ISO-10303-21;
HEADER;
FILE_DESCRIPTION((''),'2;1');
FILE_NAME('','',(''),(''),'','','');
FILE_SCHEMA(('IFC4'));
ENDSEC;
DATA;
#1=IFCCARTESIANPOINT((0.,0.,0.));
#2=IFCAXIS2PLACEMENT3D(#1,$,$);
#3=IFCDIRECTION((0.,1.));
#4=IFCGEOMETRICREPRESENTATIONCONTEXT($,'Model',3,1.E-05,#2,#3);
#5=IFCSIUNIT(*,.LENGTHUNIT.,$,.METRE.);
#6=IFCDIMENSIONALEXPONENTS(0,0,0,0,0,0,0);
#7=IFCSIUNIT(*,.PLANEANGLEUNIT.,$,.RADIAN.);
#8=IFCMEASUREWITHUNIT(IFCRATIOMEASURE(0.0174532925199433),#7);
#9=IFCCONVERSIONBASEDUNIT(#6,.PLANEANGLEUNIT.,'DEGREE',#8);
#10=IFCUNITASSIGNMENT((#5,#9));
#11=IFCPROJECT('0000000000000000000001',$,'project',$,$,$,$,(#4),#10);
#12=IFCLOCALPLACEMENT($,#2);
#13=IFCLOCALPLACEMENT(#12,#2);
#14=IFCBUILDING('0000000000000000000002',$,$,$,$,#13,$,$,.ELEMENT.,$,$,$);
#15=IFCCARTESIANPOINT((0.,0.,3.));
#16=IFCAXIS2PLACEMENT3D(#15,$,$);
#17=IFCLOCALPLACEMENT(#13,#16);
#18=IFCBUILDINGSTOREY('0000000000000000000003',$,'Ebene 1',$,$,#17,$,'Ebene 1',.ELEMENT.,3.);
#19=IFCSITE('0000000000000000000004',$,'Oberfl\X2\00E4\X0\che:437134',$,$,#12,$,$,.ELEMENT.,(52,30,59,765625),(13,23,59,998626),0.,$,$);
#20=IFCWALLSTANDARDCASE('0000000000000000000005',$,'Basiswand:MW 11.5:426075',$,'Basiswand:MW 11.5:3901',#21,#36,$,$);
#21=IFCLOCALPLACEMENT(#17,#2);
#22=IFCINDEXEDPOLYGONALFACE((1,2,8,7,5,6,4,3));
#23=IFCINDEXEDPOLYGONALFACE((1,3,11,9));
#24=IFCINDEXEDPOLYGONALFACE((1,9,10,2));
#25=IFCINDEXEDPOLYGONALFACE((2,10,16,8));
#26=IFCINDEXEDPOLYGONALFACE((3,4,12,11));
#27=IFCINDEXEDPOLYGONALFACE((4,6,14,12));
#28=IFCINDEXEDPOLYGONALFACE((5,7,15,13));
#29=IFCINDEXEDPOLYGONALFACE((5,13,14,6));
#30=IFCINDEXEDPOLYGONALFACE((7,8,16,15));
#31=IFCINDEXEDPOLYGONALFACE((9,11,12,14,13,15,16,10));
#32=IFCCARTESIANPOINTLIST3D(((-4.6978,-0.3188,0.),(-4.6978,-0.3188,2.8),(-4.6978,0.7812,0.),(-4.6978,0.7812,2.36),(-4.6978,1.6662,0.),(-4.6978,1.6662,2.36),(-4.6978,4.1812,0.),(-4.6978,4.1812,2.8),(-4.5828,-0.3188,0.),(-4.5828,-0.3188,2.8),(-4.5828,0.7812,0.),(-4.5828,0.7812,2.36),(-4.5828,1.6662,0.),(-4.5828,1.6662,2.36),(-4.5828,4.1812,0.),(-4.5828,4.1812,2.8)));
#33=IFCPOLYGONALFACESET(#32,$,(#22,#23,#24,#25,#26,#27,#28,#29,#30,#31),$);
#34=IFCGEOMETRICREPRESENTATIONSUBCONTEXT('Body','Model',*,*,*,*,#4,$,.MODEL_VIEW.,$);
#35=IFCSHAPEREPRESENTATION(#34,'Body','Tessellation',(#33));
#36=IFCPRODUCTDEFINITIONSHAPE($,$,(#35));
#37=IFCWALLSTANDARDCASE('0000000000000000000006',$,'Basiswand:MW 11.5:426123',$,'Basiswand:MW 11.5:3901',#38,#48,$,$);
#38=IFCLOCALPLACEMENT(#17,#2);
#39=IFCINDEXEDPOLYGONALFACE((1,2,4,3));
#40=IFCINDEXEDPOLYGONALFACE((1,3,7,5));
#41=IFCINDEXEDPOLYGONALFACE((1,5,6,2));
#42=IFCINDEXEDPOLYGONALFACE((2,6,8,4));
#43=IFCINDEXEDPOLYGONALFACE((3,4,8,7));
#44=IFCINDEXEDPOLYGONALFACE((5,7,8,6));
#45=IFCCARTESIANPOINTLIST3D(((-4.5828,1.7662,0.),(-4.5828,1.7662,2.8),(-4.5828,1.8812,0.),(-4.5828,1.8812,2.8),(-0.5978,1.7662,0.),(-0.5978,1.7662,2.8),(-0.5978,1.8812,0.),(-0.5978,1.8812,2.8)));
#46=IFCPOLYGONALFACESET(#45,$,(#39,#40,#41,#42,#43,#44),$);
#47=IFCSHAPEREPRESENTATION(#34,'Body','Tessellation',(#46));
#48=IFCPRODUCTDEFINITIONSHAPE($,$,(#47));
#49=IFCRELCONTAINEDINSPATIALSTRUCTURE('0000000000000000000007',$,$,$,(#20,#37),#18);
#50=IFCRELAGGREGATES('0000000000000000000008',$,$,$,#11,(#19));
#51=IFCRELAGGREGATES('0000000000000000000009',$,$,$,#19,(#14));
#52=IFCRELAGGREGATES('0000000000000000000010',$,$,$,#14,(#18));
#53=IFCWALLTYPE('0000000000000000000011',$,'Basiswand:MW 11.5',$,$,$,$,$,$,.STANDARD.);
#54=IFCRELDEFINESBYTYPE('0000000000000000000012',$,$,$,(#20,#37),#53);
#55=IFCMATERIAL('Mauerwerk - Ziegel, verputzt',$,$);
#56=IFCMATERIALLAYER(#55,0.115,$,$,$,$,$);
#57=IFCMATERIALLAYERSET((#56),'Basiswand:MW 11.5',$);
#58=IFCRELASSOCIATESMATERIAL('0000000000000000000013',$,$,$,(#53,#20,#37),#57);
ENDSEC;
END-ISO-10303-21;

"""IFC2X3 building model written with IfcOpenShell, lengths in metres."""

from ifc_helpers import new_model, entity, si_unit, converted_unit, direction, frame, frame_2d, origin, place, context, subcontext, project, spatial, polyline, rectangle, extrude, clip, bounded_halfspace, material, layer, layer_set, layer_usage, type_object, element, save


model = new_model("IFC2X3")

# Units and contexts
model_context = context("Model", 3, precision=1e-05, world=origin(), true_north=direction((0.0, 1.0)))
body_context = subcontext(model_context, "Body", "Model", "MODEL_VIEW")
ifc_project = project(units=[si_unit("LENGTHUNIT", "METRE"), converted_unit("PLANEANGLEUNIT", "DEGREE", entity("IfcRatioMeasure", 0.0174532925199433), si_unit("PLANEANGLEUNIT", "RADIAN"), dimensions=[0, 0, 0, 0, 0, 0, 0])], contexts=[model_context])

# Site, building, storey
site_placement = place(None, origin())
site = spatial("IfcSite", under=ifc_project, at=site_placement, Name="Oberfläche:437134", CompositionType="ELEMENT", RefLatitude=(52, 30, 59, 765625), RefLongitude=(13, 23, 59, 998626), RefElevation=0.0)
building_placement = place(site_placement, origin())
building = spatial("IfcBuilding", under=site, at=building_placement, CompositionType="ELEMENT")
storey_placement = place(building_placement, frame((0.0, 0.0, 3.0)))
storey = spatial("IfcBuildingStorey", under=building, at=storey_placement, Name="Ebene 1", LongName="Ebene 1", CompositionType="ELEMENT", Elevation=3.0)

# Shared definitions
ifc_material_1 = material(Name="Mauerwerk - Ziegel, verputzt")

# Wall, opening
ifc_layer_1 = layer(ifc_material_1, 0.115)
ifc_layer_set_1 = layer_set([ifc_layer_1], Name="Basiswand:MW 11.5")
ifc_layer_usage_1 = layer_usage(ifc_layer_set_1, "AXIS2", "POSITIVE", -0.0575)
wall_type_1 = type_object("IfcWallType", Name="Basiswand:MW 11.5", PredefinedType="STANDARD", material=ifc_layer_set_1)
wall_1_placement = place(storey_placement, frame((-4.6403, -0.3188, 0.0), z_axis=(0.0, 0.0, 1.0), x_axis=(0.0, 1.0, 0.0)))
wall_1 = element("IfcWallStandardCase", 1, at=wall_1_placement, inside=storey, type_object=wall_type_1, material=ifc_layer_usage_1, Name="Basiswand:MW 11.5:426075", ObjectType="Basiswand:MW 11.5:3901", context=body_context, shape_type="Clipping", body=[
    clip(extrude(rectangle(XDim=4.5, YDim=0.115, at=frame_2d((2.25, 0.0), x_axis=(-1.0, 0.0))), origin(), (0.0, 0.0, 1.0), 2.8), bounded_halfspace(frame((0.0, -0.0575, 2.8), z_axis=(0.0, 0.0, -1.0), x_axis=(-1.0, 0.0, 0.0)), True, frame((0.0, -0.0575, 2.8)), polyline([(0.0, 0.0), (2.085, 0.0), (2.2, 0.0), (4.5, 0.0), (4.5, 0.115), (0.0, 0.115), (0.0, 0.0)]))),
])
opening_1_placement = place(wall_1_placement, frame((1.985, 0.0575, 0.0)))
element("IfcOpeningElement", 2, at=opening_1_placement, cuts=wall_1, ObjectType="Opening", context=body_context, shape_type="SweptSolid", body=[
    extrude(rectangle(XDim=2.36, YDim=0.885, at=frame_2d((1.18, 0.4425), x_axis=(1.0, 0.0))), frame((0.0, 0.0, 0.0), z_axis=(0.0, -1.0, 0.0), x_axis=(0.0, 0.0, 1.0)), (0.0, 0.0, 1.0), 0.115),
])

# Wall
ifc_layer_usage_2 = layer_usage(ifc_layer_set_1, "AXIS2", "POSITIVE", -0.0575)
wall_2_placement = place(storey_placement, frame((-4.5828, 1.8237, 0.0)))
element("IfcWallStandardCase", 3, at=wall_2_placement, inside=storey, type_object=wall_type_1, material=ifc_layer_usage_2, Name="Basiswand:MW 11.5:426123", ObjectType="Basiswand:MW 11.5:3901", context=body_context, shape_type="Clipping", body=[
    clip(extrude(rectangle(XDim=3.985, YDim=0.115, at=frame_2d((1.9925, 0.0), x_axis=(-1.0, 0.0))), origin(), (0.0, 0.0, 1.0), 2.8), bounded_halfspace(frame((0.0, -0.0575, 2.8), z_axis=(0.0, 0.0, -1.0), x_axis=(0.0, -1.0, 0.0)), True, frame((0.0, -0.0575, 2.8)), polyline([(0.0, 0.0), (3.985, 0.0), (3.985, 0.115), (0.0, 0.115), (0.0, 0.0)]))),
])

save(model, "model.ifc")
